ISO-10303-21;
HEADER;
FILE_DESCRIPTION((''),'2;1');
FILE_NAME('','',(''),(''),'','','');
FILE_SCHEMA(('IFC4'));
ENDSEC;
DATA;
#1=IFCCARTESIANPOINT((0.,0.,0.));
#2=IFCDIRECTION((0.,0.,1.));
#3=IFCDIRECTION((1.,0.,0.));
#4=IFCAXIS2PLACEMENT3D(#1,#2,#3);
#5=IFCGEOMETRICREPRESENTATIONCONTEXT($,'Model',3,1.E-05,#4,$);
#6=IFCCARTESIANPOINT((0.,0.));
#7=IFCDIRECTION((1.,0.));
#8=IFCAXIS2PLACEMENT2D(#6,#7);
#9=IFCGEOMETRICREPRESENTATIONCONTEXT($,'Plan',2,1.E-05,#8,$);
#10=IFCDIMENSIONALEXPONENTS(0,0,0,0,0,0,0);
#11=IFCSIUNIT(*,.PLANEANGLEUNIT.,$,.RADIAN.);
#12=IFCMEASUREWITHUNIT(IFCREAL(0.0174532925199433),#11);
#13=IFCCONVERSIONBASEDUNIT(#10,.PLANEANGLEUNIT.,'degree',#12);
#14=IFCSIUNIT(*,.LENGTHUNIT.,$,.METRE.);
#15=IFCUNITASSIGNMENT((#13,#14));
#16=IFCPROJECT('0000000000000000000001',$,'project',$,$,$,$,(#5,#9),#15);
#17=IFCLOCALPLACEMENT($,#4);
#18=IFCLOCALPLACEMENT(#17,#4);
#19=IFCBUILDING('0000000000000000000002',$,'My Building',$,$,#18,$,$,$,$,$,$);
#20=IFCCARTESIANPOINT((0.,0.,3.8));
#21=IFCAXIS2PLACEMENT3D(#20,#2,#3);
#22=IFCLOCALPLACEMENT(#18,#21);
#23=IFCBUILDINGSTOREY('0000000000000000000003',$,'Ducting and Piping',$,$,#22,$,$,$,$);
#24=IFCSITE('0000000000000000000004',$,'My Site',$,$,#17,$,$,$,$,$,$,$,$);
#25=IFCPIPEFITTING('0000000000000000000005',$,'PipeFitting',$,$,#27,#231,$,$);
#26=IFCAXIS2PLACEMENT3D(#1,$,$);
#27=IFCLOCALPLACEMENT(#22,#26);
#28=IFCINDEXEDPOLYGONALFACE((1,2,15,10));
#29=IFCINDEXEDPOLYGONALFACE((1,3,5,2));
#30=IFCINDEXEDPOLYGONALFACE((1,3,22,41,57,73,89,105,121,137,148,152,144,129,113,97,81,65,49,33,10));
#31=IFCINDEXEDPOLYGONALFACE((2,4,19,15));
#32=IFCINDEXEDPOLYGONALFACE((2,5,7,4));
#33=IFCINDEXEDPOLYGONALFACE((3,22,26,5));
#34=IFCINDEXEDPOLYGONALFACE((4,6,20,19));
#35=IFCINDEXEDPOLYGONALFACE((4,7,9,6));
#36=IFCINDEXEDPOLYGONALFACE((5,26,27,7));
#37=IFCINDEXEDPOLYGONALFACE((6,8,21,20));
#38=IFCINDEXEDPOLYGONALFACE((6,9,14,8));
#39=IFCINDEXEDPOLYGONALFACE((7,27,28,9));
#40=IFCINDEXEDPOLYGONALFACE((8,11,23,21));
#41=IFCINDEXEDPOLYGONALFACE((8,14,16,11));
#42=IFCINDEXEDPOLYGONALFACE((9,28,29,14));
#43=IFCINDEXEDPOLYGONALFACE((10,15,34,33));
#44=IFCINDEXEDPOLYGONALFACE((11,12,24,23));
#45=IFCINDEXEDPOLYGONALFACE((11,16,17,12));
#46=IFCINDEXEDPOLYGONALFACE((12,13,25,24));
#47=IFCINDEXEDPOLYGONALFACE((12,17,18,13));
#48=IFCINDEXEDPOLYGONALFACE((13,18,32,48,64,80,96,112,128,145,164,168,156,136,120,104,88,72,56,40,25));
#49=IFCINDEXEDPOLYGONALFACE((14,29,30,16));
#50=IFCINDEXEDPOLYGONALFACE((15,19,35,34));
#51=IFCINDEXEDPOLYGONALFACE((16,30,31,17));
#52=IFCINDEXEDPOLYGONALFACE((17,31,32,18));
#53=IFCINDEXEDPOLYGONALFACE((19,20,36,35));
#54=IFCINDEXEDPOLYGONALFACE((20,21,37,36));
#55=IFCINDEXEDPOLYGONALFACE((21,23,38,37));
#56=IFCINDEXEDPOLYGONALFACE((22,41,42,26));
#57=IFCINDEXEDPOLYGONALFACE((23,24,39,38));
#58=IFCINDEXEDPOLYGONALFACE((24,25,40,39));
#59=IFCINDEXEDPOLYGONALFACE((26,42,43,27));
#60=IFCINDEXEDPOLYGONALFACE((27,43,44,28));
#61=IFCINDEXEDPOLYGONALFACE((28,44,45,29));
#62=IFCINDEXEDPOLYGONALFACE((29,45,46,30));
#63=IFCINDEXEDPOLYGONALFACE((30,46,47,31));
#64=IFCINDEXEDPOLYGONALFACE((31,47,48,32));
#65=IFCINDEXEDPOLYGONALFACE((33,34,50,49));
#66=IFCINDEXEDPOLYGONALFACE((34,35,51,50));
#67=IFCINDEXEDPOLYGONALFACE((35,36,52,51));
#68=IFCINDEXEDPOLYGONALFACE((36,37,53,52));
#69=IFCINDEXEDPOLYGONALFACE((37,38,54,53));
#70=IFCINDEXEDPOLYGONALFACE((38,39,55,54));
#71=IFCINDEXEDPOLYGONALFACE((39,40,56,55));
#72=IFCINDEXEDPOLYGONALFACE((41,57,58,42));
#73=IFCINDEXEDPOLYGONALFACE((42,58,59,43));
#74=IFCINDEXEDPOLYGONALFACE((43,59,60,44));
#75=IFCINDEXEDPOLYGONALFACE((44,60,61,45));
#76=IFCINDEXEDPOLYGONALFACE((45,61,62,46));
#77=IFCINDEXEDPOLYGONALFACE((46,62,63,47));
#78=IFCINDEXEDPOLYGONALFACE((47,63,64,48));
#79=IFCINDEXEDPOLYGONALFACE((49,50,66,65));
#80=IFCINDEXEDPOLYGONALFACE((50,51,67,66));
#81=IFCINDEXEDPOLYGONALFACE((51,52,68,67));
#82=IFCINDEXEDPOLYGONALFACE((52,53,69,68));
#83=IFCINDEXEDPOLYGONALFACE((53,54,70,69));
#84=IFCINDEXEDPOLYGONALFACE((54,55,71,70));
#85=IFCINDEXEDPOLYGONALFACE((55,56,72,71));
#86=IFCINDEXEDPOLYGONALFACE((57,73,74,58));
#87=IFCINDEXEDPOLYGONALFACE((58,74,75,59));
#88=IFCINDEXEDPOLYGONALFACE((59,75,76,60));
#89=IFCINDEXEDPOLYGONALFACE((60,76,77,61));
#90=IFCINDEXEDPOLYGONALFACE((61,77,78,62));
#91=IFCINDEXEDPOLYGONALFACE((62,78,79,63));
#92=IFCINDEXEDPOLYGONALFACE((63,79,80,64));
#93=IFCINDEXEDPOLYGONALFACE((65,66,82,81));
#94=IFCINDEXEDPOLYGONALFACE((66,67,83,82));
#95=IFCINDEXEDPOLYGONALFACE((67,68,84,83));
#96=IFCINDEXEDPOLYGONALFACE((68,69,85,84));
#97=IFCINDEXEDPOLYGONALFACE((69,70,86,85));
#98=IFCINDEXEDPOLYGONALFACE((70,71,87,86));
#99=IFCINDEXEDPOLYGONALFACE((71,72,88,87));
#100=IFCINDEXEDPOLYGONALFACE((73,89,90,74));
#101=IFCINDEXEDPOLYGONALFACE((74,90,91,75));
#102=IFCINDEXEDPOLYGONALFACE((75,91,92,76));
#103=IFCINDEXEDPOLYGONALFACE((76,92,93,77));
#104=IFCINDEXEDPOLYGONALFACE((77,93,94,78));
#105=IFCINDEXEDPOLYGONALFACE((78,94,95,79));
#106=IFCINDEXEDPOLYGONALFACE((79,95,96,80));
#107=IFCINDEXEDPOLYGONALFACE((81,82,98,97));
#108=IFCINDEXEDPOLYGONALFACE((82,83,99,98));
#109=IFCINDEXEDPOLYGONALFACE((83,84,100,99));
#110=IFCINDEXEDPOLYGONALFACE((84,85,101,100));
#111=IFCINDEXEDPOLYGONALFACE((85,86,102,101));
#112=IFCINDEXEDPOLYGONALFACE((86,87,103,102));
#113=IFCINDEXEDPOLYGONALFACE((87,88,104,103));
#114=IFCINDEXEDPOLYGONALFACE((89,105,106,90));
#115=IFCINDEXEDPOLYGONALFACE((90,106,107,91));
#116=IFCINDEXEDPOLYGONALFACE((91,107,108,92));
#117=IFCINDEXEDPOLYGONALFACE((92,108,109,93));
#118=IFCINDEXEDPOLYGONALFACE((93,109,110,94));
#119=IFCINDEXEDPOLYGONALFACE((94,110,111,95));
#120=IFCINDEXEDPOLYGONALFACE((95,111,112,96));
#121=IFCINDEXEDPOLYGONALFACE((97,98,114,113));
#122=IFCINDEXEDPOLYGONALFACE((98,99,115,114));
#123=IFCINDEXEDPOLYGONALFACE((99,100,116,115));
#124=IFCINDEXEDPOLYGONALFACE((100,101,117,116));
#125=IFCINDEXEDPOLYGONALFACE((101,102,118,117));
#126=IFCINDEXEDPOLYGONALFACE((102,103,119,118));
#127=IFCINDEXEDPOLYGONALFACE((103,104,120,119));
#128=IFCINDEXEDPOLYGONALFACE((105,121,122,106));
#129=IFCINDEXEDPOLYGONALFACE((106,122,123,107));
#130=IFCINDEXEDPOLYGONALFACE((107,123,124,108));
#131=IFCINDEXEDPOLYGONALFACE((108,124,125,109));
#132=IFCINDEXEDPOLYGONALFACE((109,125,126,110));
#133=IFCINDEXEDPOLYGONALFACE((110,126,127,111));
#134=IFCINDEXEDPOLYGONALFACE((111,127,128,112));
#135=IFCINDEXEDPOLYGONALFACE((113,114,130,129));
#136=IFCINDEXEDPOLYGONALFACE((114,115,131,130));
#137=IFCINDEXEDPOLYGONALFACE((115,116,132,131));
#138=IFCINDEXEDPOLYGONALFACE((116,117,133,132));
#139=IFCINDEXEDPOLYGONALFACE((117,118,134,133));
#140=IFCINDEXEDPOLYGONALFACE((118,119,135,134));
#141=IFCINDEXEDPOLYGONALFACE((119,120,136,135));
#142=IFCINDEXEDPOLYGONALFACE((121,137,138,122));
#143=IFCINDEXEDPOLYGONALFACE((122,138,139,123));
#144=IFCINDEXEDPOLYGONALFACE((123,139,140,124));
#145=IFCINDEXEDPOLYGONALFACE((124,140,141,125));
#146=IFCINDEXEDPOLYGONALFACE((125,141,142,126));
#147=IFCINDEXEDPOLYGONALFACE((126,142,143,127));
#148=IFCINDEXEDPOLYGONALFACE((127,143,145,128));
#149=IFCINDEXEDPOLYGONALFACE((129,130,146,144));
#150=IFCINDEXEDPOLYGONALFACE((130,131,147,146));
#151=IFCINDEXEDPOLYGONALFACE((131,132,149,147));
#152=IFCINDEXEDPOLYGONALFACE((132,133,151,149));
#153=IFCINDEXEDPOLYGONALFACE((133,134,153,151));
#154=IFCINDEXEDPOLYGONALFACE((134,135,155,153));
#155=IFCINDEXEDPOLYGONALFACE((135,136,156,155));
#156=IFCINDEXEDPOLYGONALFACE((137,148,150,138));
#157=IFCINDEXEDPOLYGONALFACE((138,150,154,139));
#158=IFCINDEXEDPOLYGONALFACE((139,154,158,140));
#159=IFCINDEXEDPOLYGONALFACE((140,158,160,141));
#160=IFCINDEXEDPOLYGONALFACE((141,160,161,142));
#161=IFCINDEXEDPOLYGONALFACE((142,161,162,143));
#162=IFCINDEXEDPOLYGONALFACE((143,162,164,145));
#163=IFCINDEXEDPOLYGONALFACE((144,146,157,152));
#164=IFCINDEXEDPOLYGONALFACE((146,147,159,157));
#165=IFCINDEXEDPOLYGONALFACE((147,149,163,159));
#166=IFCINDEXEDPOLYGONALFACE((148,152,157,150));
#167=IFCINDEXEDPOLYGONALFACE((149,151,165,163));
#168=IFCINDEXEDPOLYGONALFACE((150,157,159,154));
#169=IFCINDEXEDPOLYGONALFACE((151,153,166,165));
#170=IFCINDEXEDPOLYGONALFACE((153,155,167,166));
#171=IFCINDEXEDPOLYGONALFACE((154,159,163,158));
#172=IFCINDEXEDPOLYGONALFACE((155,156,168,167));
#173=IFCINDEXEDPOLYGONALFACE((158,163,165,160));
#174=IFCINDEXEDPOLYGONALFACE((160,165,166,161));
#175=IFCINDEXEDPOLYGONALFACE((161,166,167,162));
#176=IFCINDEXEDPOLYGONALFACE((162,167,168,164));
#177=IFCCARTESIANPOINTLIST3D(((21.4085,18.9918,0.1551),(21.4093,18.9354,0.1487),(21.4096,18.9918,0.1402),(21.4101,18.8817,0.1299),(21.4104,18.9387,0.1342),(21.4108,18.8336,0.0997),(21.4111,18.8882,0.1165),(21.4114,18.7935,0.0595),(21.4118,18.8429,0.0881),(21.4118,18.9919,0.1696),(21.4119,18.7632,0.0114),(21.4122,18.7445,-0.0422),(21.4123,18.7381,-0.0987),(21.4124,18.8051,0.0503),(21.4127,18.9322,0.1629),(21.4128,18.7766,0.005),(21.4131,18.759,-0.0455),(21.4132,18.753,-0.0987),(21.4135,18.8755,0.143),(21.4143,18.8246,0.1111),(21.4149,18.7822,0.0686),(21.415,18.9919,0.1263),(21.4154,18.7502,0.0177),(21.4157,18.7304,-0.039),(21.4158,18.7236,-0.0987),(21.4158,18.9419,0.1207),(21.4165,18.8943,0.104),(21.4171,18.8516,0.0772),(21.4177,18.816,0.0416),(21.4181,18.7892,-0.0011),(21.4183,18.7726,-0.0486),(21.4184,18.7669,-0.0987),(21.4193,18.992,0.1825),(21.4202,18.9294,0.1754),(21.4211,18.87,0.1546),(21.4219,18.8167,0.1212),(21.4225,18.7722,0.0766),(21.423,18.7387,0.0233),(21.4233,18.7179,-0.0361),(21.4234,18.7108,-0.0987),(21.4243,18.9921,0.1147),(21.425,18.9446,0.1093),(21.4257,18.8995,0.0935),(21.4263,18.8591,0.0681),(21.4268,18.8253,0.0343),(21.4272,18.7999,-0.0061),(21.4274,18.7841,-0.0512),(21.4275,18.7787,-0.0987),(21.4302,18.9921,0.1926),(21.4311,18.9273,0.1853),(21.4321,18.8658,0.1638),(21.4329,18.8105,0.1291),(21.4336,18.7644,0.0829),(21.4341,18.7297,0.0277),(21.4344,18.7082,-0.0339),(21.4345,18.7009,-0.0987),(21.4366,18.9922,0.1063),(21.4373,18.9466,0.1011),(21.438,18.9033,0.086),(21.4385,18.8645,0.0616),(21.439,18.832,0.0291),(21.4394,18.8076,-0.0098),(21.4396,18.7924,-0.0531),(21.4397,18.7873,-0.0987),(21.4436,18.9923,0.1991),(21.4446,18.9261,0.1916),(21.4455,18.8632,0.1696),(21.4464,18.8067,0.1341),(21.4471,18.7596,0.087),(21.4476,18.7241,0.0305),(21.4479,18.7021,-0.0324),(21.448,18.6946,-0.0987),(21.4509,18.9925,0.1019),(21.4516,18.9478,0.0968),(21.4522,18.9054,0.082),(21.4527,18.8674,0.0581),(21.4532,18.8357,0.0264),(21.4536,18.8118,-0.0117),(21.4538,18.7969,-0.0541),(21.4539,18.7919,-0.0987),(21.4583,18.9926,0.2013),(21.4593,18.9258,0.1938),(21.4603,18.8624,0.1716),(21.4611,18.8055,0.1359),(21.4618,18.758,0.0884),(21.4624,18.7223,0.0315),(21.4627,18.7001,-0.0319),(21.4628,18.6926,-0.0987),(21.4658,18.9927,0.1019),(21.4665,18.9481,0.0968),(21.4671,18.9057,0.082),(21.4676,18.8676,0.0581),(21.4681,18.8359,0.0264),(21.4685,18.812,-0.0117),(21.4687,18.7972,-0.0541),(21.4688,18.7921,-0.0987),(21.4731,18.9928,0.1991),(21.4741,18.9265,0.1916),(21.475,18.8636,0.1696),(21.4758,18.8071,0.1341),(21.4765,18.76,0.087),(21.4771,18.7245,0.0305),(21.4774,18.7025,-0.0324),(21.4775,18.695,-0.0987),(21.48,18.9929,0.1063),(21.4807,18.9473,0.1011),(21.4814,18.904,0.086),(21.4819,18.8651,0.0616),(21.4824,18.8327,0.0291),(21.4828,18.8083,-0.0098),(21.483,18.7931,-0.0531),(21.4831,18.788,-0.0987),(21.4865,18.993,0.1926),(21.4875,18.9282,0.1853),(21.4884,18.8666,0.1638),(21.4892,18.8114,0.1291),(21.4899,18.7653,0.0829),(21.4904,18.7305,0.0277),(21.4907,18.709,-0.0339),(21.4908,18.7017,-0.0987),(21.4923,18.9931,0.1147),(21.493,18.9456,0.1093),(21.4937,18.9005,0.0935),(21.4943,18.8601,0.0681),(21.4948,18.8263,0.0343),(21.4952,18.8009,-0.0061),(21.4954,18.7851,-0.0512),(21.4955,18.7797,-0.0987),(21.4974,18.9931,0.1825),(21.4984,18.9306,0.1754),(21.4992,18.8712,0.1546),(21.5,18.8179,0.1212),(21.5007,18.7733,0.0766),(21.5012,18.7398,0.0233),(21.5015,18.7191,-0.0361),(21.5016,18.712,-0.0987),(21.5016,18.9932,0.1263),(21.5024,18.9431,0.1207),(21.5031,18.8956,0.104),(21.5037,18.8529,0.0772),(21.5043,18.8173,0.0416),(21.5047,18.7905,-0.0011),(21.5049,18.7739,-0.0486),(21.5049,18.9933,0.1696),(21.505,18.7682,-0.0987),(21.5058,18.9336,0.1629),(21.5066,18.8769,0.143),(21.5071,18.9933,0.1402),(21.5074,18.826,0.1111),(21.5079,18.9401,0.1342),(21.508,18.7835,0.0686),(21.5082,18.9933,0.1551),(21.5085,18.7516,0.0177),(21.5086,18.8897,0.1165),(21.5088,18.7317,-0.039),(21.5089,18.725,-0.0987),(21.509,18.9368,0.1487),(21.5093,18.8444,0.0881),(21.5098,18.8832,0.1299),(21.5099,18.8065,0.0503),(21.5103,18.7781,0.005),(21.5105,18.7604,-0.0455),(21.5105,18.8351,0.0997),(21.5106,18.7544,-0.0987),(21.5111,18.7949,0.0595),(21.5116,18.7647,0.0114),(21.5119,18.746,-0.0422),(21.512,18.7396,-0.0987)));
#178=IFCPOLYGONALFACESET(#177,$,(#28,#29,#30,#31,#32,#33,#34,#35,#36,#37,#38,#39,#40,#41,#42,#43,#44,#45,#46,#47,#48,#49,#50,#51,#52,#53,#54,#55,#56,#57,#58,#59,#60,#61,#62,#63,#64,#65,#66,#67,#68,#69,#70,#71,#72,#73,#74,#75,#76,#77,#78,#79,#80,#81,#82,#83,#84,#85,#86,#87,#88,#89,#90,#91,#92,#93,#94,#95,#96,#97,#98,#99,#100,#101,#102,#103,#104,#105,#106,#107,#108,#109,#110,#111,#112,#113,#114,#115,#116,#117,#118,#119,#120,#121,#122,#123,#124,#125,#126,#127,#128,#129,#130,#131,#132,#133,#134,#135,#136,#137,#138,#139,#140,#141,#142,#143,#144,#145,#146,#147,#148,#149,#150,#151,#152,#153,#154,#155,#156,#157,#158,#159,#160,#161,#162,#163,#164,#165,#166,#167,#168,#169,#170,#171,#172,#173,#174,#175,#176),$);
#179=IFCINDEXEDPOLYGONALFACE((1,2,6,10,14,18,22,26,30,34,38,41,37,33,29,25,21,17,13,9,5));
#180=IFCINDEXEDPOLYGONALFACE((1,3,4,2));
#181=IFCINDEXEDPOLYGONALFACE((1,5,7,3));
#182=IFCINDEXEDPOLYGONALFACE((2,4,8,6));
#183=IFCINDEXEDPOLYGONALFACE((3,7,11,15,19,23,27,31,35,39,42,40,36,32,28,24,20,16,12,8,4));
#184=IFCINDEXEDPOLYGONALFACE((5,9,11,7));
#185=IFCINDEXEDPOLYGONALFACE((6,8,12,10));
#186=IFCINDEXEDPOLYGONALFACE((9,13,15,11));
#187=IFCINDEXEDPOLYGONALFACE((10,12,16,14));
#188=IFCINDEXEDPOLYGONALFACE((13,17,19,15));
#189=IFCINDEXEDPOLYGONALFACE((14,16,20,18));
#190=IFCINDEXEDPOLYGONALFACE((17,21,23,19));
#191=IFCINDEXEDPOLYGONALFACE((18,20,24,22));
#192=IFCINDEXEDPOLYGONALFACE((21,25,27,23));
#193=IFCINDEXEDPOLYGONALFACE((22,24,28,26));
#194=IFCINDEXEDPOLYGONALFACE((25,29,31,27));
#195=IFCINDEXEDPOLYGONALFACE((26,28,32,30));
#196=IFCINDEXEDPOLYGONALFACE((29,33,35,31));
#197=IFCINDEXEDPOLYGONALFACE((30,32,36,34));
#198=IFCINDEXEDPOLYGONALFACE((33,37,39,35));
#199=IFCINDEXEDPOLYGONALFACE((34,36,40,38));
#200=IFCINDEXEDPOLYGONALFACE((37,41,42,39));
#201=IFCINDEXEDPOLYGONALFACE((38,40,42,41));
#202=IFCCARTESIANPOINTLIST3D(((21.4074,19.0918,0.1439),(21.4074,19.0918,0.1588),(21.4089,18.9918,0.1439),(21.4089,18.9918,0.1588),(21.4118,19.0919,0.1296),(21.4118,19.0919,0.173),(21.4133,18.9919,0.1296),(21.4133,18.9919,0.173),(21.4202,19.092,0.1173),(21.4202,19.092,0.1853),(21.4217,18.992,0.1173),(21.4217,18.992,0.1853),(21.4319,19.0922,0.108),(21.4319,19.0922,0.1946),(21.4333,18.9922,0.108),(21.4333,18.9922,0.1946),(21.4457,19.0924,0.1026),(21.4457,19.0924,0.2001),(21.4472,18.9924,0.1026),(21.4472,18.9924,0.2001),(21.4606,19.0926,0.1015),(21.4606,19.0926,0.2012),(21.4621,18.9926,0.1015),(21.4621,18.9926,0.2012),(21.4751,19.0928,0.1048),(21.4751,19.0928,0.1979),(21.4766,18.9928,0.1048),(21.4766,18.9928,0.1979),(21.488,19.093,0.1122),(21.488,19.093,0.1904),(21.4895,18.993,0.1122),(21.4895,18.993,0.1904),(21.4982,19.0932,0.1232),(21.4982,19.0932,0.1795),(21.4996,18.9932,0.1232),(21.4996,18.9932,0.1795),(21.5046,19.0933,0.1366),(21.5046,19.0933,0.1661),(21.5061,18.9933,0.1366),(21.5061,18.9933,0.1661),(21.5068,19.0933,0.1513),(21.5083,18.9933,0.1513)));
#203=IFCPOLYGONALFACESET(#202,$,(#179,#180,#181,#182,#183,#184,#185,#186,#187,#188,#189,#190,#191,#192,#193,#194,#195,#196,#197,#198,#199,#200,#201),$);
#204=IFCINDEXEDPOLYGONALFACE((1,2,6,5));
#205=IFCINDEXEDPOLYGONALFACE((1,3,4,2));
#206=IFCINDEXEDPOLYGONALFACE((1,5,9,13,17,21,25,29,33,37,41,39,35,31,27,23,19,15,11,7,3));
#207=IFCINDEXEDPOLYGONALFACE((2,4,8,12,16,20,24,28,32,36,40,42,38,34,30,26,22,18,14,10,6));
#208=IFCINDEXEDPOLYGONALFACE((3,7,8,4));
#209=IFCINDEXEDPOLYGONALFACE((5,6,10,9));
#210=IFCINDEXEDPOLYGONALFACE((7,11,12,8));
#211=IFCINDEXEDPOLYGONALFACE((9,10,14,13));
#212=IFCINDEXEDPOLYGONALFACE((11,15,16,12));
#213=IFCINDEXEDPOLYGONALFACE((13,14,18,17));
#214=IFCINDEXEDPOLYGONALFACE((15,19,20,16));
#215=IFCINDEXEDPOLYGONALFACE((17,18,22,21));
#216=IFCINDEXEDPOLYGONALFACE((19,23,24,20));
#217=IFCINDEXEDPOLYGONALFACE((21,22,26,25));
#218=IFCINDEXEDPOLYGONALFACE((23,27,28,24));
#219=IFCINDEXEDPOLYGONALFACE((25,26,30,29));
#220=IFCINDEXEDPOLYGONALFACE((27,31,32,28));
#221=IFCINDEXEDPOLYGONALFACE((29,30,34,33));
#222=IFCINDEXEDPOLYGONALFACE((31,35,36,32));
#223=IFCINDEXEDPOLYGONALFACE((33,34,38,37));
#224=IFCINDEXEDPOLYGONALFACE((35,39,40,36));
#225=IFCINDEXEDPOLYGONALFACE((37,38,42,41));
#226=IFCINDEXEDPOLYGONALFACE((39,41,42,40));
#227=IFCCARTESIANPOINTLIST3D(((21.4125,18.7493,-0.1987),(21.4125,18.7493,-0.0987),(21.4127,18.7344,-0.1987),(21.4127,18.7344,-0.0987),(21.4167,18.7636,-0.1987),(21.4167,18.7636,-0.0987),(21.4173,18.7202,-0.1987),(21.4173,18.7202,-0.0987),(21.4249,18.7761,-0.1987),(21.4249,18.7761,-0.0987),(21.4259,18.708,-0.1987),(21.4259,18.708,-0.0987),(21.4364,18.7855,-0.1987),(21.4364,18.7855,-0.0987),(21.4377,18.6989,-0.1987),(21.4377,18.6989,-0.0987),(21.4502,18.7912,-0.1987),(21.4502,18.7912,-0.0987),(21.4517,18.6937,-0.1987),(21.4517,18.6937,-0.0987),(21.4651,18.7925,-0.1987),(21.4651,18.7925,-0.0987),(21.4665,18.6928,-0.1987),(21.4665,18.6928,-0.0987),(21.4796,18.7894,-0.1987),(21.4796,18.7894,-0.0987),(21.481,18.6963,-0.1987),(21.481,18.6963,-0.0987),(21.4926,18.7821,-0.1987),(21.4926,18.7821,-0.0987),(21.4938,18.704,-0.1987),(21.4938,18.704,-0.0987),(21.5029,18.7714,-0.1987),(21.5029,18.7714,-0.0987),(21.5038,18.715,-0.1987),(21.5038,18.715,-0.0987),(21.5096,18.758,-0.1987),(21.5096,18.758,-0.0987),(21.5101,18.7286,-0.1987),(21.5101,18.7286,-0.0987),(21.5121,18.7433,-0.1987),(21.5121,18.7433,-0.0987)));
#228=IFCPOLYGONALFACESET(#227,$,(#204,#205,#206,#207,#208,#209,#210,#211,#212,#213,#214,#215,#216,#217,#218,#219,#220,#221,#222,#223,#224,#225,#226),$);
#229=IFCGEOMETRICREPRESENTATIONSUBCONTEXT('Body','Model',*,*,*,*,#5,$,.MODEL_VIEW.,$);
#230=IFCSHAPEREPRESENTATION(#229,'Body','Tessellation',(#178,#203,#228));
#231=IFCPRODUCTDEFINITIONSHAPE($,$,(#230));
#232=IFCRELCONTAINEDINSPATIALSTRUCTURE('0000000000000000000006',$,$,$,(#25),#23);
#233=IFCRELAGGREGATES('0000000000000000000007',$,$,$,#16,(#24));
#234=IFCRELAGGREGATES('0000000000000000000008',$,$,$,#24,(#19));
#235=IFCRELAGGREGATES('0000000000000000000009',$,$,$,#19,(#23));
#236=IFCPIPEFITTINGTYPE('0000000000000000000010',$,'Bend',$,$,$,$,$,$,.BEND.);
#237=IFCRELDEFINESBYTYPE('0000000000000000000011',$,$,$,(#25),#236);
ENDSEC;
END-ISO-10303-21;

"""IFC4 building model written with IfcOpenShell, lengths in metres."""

from ifc_helpers import new_model, entity, si_unit, converted_unit, frame, origin_with_axes, origin_2d_with_axis, place, context, subcontext, project, spatial, circle, extrude, source, transform, mapped, type_object, type_shapes, element, save


model = new_model("IFC4")

# Units and contexts
model_context = context("Model", 3, precision=1e-05, world=origin_with_axes())
plan_context = context("Plan", 2, precision=1e-05, world=origin_2d_with_axis())
body_context = subcontext(model_context, "Body", "Model", "MODEL_VIEW")
ifc_project = project(units=[converted_unit("PLANEANGLEUNIT", "degree", entity("IfcReal", 0.0174532925199433), si_unit("PLANEANGLEUNIT", "RADIAN"), dimensions=[0, 0, 0, 0, 0, 0, 0]), si_unit("LENGTHUNIT", "METRE")], contexts=[model_context, plan_context])

# Site, building, storey
site_placement = place(None, origin_with_axes())
site = spatial("IfcSite", under=ifc_project, at=site_placement, Name="My Site")
building_placement = place(site_placement, origin_with_axes())
building = spatial("IfcBuilding", under=site, at=building_placement, Name="My Building")
storey_placement = place(building_placement, frame((0.0, 0.0, 3.8), z_axis=(0.0, 0.0, 1.0), x_axis=(1.0, 0.0, 0.0)))
storey = spatial("IfcBuildingStorey", under=building, at=storey_placement, Name="Ducting and Piping")

# Pipe fitting
pipe_fitting_type = type_object("IfcPipeFittingType", Name="Bend", PredefinedType="BEND")
shared_shape = source(origin_with_axes(), body_context, "Body", "SolidModel", [
    entity("IfcSweptDiskSolid", entity("IfcIndexedPolyCurve", entity("IfcCartesianPointList3D", [[0.0, 0.0, 0.1], [0.0, -0.0732, 0.2768], [0.0, -0.25, 0.35]]), [entity("IfcArcIndex", [1, 2, 3])]), 0.05),
    extrude(circle(Radius=0.05), origin_with_axes(), (0.0, 0.0, 1.0), 0.1),
    extrude(circle(Radius=0.05), frame((0.0, -0.25, 0.35), z_axis=(0.0, -1.0, 0.0), x_axis=(1.0, 0.0, 0.0)), (0.0, 0.0, 1.0), 0.1),
])
type_shapes(pipe_fitting_type, [shared_shape])
for number, where, z_axis, x_axis, name in (
    (1, (21.4569, 19.0926, 0.1513), (0.014879, -0.999889, 0.0), (0.999889, 0.014879, 0.0), "PipeFitting"),
):
    element("IfcPipeFitting", number, at=place(storey_placement, frame(where, z_axis=z_axis, x_axis=x_axis)), inside=storey, type_object=pipe_fitting_type, Name=name, context=body_context, shape_type="MappedRepresentation", body=[
        mapped(shared_shape, transform((0.0, 0.0, 0.0), x_axis=(1.0, 0.0, 0.0), y_axis=(0.0, 1.0, 0.0), z_axis=(0.0, 0.0, 1.0), scale=1.0)),
    ])

save(model, "model.ifc")
